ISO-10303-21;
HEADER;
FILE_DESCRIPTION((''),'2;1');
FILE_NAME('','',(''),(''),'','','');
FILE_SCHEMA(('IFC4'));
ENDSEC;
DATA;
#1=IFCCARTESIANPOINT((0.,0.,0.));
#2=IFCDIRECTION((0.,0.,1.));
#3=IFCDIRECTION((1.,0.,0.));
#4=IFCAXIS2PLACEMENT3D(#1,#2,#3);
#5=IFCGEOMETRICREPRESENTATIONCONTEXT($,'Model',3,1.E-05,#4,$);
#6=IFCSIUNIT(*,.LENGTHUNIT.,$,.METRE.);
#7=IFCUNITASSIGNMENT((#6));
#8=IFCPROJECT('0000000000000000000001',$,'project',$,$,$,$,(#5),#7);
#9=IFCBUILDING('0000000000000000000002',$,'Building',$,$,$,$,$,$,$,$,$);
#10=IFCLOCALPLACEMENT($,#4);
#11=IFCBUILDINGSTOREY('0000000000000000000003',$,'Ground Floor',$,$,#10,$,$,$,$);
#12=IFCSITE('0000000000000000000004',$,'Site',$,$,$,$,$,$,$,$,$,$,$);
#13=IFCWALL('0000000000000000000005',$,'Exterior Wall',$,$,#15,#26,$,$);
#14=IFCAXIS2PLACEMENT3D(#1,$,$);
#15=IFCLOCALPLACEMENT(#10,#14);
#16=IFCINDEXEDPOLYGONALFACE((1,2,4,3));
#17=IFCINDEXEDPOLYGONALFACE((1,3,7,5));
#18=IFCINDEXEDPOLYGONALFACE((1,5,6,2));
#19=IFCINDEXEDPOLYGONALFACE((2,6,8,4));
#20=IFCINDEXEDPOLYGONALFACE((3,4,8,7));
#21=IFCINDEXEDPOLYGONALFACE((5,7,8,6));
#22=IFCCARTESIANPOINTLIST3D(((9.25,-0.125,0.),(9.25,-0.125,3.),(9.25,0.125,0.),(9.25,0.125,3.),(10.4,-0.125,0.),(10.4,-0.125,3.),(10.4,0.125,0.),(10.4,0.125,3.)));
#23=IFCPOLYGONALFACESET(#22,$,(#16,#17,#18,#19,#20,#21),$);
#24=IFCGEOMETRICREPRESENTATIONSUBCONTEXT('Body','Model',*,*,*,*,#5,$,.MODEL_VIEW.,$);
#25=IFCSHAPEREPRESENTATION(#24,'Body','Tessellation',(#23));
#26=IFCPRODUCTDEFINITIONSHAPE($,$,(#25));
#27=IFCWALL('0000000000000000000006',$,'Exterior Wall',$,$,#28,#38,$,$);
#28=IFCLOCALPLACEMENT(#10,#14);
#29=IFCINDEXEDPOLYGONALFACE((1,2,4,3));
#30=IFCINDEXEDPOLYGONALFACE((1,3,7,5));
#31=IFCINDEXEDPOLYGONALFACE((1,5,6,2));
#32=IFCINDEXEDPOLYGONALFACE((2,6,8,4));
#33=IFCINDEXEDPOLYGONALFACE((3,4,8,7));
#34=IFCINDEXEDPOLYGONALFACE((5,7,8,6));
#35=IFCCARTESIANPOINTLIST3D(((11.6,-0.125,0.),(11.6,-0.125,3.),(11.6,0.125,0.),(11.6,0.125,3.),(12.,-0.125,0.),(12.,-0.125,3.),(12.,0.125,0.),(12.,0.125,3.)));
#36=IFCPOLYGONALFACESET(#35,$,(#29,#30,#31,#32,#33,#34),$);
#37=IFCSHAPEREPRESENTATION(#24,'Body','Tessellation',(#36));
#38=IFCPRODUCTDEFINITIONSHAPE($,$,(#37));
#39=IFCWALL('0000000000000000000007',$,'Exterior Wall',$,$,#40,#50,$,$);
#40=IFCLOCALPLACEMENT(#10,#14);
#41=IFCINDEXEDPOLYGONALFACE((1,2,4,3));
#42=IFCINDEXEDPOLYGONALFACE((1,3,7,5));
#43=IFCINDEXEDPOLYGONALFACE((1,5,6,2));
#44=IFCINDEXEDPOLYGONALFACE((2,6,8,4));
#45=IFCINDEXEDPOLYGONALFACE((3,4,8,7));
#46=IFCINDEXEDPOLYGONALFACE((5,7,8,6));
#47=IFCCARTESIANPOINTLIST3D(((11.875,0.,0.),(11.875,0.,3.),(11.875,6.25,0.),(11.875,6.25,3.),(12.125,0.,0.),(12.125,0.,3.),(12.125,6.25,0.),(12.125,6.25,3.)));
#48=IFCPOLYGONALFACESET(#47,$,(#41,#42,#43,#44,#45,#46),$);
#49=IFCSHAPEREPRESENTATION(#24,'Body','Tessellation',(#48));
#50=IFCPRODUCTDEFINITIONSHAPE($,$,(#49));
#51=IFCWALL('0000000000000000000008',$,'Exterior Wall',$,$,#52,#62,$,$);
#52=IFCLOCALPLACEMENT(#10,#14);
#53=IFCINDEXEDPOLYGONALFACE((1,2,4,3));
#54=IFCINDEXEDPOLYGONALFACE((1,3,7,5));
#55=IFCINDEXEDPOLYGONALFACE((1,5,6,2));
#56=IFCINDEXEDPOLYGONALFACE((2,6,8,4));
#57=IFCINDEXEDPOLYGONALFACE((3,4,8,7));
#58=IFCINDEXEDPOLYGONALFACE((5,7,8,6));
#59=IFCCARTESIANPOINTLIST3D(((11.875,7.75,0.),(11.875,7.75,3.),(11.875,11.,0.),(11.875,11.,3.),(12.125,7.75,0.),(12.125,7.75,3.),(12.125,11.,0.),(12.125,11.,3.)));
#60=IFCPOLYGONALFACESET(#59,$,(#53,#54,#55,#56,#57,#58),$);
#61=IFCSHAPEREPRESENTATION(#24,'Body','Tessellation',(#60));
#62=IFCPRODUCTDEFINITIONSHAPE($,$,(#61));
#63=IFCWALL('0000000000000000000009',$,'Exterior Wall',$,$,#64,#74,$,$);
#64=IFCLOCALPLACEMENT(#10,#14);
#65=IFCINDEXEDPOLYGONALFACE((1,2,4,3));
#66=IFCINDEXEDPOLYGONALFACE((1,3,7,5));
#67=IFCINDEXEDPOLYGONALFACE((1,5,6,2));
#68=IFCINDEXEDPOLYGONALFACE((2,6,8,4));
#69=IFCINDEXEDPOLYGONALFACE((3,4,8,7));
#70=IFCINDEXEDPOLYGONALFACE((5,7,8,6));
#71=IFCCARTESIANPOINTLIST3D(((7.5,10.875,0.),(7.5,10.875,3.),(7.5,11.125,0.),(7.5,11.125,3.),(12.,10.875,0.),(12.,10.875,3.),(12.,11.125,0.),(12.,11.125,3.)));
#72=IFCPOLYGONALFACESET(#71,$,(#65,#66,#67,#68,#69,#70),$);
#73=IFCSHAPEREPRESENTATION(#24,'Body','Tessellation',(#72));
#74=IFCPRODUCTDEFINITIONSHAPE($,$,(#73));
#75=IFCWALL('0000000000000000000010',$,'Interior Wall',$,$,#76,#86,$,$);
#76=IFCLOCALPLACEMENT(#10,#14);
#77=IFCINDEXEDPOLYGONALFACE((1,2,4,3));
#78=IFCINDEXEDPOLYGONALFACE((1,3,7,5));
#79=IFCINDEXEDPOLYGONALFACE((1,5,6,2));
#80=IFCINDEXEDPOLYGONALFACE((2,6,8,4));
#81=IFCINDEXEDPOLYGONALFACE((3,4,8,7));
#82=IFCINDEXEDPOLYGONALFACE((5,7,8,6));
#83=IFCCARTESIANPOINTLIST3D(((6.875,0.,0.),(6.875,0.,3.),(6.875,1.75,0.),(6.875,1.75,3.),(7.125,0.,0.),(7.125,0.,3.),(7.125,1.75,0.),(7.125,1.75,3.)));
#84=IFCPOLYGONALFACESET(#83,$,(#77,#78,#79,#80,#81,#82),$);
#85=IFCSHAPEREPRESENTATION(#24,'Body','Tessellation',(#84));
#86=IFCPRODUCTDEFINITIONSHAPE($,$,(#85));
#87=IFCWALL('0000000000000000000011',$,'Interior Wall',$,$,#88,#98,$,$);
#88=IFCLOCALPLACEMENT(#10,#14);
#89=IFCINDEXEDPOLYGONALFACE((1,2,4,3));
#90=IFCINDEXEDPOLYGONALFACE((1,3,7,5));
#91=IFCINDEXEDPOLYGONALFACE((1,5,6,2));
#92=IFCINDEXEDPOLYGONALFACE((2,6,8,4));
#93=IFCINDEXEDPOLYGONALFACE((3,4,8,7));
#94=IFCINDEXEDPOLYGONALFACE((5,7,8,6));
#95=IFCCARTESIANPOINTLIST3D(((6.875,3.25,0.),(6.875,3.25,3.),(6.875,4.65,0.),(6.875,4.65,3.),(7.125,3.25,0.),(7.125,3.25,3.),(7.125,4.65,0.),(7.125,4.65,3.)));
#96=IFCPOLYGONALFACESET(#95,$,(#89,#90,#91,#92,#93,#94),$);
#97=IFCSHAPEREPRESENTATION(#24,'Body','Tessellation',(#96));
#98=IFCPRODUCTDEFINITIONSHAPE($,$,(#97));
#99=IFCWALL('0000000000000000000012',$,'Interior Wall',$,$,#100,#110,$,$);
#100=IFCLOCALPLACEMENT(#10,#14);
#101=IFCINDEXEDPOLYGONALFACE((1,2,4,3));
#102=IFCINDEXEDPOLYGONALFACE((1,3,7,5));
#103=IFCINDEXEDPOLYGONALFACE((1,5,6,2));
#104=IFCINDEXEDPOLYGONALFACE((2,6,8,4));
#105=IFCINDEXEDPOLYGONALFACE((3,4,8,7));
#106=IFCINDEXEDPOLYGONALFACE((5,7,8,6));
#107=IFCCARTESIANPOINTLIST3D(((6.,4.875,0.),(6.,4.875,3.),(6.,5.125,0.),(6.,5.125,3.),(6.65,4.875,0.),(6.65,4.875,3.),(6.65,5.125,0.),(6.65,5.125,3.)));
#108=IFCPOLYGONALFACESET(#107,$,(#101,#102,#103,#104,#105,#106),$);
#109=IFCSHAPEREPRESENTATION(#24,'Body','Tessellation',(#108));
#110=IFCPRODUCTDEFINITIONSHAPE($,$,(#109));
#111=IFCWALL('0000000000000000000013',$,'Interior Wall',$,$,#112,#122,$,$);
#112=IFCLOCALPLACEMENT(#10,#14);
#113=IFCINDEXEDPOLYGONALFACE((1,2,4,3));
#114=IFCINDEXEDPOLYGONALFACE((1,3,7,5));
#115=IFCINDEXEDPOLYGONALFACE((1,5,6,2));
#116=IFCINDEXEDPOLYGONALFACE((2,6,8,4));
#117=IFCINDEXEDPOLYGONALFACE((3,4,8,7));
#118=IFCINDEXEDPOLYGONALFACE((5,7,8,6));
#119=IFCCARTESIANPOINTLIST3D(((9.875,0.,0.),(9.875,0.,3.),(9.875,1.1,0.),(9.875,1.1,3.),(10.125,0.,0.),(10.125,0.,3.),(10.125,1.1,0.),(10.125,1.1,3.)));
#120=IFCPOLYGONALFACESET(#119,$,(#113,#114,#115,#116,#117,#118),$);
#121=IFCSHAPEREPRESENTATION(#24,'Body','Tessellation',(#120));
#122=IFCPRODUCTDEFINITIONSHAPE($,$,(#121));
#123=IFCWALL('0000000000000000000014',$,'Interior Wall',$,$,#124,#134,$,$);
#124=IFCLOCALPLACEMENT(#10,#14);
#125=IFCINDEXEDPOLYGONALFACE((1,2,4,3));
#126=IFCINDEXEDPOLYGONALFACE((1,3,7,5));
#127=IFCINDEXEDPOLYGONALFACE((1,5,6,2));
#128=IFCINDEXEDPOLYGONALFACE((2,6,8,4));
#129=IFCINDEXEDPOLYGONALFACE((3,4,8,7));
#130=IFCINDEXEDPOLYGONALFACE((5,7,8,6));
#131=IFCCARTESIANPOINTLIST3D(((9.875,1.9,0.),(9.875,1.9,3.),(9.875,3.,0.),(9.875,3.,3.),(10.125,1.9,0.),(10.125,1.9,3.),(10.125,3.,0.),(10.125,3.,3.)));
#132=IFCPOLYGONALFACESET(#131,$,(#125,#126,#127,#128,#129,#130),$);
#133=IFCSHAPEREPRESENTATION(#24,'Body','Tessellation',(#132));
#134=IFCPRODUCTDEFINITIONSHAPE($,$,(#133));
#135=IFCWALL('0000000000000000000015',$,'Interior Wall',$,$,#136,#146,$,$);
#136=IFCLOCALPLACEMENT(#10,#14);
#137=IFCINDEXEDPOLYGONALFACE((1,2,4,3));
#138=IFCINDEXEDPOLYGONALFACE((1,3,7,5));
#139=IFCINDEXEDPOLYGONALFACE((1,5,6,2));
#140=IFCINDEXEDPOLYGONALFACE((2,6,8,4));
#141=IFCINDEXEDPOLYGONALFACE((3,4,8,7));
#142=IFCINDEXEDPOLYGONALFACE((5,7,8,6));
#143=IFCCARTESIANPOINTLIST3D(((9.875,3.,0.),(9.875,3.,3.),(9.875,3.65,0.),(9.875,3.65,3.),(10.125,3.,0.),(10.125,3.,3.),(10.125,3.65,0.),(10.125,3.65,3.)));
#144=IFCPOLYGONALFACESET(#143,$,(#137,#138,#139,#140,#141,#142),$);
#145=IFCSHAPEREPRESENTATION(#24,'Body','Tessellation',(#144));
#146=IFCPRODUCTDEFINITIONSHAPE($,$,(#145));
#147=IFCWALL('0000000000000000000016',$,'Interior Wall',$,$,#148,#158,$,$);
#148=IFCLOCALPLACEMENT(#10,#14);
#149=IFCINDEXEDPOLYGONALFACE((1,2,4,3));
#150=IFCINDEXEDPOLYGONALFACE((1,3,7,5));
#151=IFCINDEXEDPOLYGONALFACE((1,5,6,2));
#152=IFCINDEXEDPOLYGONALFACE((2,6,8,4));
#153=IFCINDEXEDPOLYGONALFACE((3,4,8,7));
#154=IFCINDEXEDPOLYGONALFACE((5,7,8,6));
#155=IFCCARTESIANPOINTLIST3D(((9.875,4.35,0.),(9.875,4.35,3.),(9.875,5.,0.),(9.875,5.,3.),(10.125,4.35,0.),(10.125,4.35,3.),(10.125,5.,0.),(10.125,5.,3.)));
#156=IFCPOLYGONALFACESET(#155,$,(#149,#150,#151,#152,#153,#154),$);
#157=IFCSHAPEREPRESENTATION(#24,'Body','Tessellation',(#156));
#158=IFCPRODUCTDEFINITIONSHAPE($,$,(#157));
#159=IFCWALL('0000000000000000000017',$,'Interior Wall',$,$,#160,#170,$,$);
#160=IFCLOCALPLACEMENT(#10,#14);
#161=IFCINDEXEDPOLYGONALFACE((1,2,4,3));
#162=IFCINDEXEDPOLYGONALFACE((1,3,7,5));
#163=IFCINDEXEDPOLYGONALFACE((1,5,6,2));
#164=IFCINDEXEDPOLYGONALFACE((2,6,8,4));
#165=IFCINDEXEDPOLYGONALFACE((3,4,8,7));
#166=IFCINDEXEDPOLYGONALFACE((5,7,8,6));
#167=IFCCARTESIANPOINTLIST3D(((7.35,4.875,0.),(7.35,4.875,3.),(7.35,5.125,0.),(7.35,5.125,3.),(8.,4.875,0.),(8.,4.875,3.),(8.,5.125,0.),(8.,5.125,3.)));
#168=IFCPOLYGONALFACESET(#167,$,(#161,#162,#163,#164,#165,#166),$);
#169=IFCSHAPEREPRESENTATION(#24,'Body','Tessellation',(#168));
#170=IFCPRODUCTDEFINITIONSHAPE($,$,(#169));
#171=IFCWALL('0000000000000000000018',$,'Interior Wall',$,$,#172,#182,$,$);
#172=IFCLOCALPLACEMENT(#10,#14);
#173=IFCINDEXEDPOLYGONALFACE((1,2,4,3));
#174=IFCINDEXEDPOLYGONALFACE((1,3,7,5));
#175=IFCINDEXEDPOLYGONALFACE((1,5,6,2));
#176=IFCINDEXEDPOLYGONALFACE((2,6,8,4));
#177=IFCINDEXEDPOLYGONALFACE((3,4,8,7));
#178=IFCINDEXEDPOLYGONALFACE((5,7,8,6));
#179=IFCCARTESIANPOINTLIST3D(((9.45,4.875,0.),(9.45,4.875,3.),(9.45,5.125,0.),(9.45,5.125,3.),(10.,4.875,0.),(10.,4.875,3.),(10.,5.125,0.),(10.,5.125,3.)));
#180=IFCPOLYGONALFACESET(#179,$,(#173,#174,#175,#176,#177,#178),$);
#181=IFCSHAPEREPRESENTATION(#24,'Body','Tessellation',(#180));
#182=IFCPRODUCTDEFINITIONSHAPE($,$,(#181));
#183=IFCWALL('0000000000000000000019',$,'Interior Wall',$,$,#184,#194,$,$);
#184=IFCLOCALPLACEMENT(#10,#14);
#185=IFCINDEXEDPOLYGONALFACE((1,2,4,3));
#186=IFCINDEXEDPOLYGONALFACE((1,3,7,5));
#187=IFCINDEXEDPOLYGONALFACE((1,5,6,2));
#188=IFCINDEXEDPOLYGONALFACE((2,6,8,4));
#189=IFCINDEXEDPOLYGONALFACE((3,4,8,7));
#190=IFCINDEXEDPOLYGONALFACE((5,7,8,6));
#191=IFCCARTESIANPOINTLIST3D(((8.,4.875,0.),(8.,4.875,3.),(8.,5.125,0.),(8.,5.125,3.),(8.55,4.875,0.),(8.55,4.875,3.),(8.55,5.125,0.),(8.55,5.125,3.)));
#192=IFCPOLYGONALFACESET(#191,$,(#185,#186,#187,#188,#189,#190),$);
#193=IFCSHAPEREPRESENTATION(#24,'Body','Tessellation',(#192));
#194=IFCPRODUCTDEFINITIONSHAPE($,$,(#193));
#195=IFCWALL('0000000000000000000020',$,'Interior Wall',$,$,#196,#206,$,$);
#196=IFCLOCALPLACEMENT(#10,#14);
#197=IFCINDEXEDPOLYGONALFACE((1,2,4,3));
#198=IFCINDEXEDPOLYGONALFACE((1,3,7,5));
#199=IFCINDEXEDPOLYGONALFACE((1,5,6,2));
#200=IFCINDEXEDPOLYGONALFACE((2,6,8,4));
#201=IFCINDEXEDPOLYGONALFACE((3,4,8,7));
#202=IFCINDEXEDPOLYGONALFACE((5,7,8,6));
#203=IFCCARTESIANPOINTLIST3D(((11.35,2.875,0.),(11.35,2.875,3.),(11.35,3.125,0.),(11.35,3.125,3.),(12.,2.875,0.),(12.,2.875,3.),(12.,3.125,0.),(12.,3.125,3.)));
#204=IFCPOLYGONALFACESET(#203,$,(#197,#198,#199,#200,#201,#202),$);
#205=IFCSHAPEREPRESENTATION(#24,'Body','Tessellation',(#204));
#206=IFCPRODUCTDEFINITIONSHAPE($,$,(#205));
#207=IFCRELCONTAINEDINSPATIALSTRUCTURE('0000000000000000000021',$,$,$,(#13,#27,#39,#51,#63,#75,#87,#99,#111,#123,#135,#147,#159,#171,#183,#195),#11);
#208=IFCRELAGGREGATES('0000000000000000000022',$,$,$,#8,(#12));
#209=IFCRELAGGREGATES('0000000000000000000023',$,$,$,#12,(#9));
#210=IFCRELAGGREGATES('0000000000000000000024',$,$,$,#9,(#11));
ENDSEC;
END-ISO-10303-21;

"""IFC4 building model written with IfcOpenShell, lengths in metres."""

from ifc_helpers import new_model, si_unit, frame, origin_with_axes, place, context, subcontext, project, spatial, indexed_curve, outline, extrude, element, save


model = new_model("IFC4")

# Units and contexts
model_context = context("Model", 3, precision=1e-05, world=origin_with_axes())
body_context = subcontext(model_context, "Body", "Model", "MODEL_VIEW")
ifc_project = project(units=[si_unit("LENGTHUNIT", "METRE")], contexts=[model_context])

# Site, building, storey
site = spatial("IfcSite", under=ifc_project, Name="Site")
building = spatial("IfcBuilding", under=site, Name="Building")
storey_placement = place(None, origin_with_axes())
storey = spatial("IfcBuildingStorey", under=building, at=storey_placement, Name="Ground Floor")

# Walls
wall_1_placement = place(storey_placement, frame((9.25, 0.0, 0.0), z_axis=(0.0, 0.0, 1.0), x_axis=(1.0, 0.0, 0.0)))
element("IfcWall", 1, at=wall_1_placement, inside=storey, Name="Exterior Wall", context=body_context, shape_type="SweptSolid", body=[
    extrude(outline(indexed_curve([(0.0, 0.0), (0.0, 0.25), (1.15, 0.25), (1.15, 0.0), (0.0, 0.0)], self_intersect=False)), frame((0.0, -0.125, 0.0), z_axis=(0.0, 0.0, 1.0), x_axis=(1.0, 0.0, 0.0)), (0.0, 0.0, 1.0), 3.0),
])
wall_2_placement = place(storey_placement, frame((11.6, 0.0, 0.0), z_axis=(0.0, 0.0, 1.0), x_axis=(1.0, 0.0, 0.0)))
element("IfcWall", 2, at=wall_2_placement, inside=storey, Name="Exterior Wall", context=body_context, shape_type="SweptSolid", body=[
    extrude(outline(indexed_curve([(0.0, 0.0), (0.0, 0.25), (0.4, 0.25), (0.4, 0.0), (0.0, 0.0)], self_intersect=False)), frame((0.0, -0.125, 0.0), z_axis=(0.0, 0.0, 1.0), x_axis=(1.0, 0.0, 0.0)), (0.0, 0.0, 1.0), 3.0),
])
wall_3_placement = place(storey_placement, frame((12.0, 0.0, 0.0), z_axis=(0.0, 0.0, 1.0), x_axis=(0.0, 1.0, 0.0)))
element("IfcWall", 3, at=wall_3_placement, inside=storey, Name="Exterior Wall", context=body_context, shape_type="SweptSolid", body=[
    extrude(outline(indexed_curve([(0.0, 0.0), (0.0, 0.25), (6.25, 0.25), (6.25, 0.0), (0.0, 0.0)], self_intersect=False)), frame((0.0, -0.125, 0.0), z_axis=(0.0, 0.0, 1.0), x_axis=(1.0, 0.0, 0.0)), (0.0, 0.0, 1.0), 3.0),
])
wall_4_placement = place(storey_placement, frame((12.0, 7.75, 0.0), z_axis=(0.0, 0.0, 1.0), x_axis=(0.0, 1.0, 0.0)))
element("IfcWall", 4, at=wall_4_placement, inside=storey, Name="Exterior Wall", context=body_context, shape_type="SweptSolid", body=[
    extrude(outline(indexed_curve([(0.0, 0.0), (0.0, 0.25), (3.25, 0.25), (3.25, 0.0), (0.0, 0.0)], self_intersect=False)), frame((0.0, -0.125, 0.0), z_axis=(0.0, 0.0, 1.0), x_axis=(1.0, 0.0, 0.0)), (0.0, 0.0, 1.0), 3.0),
])
wall_5_placement = place(storey_placement, frame((12.0, 11.0, 0.0), z_axis=(0.0, 0.0, 1.0), x_axis=(-1.0, 0.0, 0.0)))
element("IfcWall", 5, at=wall_5_placement, inside=storey, Name="Exterior Wall", context=body_context, shape_type="SweptSolid", body=[
    extrude(outline(indexed_curve([(0.0, 0.0), (0.0, 0.25), (4.5, 0.25), (4.5, 0.0), (0.0, 0.0)], self_intersect=False)), frame((0.0, -0.125, 0.0), z_axis=(0.0, 0.0, 1.0), x_axis=(1.0, 0.0, 0.0)), (0.0, 0.0, 1.0), 3.0),
])
wall_6_placement = place(storey_placement, frame((7.0, 0.0, 0.0), z_axis=(0.0, 0.0, 1.0), x_axis=(0.0, 1.0, 0.0)))
element("IfcWall", 6, at=wall_6_placement, inside=storey, Name="Interior Wall", context=body_context, shape_type="SweptSolid", body=[
    extrude(outline(indexed_curve([(0.0, 0.0), (0.0, 0.25), (1.75, 0.25), (1.75, 0.0), (0.0, 0.0)], self_intersect=False)), frame((0.0, -0.125, 0.0), z_axis=(0.0, 0.0, 1.0), x_axis=(1.0, 0.0, 0.0)), (0.0, 0.0, 1.0), 3.0),
])
wall_7_placement = place(storey_placement, frame((7.0, 3.25, 0.0), z_axis=(0.0, 0.0, 1.0), x_axis=(0.0, 1.0, 0.0)))
element("IfcWall", 7, at=wall_7_placement, inside=storey, Name="Interior Wall", context=body_context, shape_type="SweptSolid", body=[
    extrude(outline(indexed_curve([(0.0, 0.0), (0.0, 0.25), (1.4, 0.25), (1.4, 0.0), (0.0, 0.0)], self_intersect=False)), frame((0.0, -0.125, 0.0), z_axis=(0.0, 0.0, 1.0), x_axis=(1.0, 0.0, 0.0)), (0.0, 0.0, 1.0), 3.0),
])
wall_8_placement = place(storey_placement, frame((6.65, 5.0, 0.0), z_axis=(0.0, 0.0, 1.0), x_axis=(-1.0, 0.0, 0.0)))
element("IfcWall", 8, at=wall_8_placement, inside=storey, Name="Interior Wall", context=body_context, shape_type="SweptSolid", body=[
    extrude(outline(indexed_curve([(0.0, 0.0), (0.0, 0.25), (0.65, 0.25), (0.65, 0.0), (0.0, 0.0)], self_intersect=False)), frame((0.0, -0.125, 0.0), z_axis=(0.0, 0.0, 1.0), x_axis=(1.0, 0.0, 0.0)), (0.0, 0.0, 1.0), 3.0),
])
for number, where, z_axis, x_axis, name in (
    (9, (10.0, 0.0, 0.0), (0.0, 0.0, 1.0), (0.0, 1.0, 0.0), "Interior Wall"),
    (10, (10.0, 1.9, 0.0), (0.0, 0.0, 1.0), (0.0, 1.0, 0.0), "Interior Wall"),
):
    element("IfcWall", number, at=place(storey_placement, frame(where, z_axis=z_axis, x_axis=x_axis)), inside=storey, Name=name, context=body_context, shape_type="SweptSolid", body=[
        extrude(outline(indexed_curve([(0.0, 0.0), (0.0, 0.25), (1.1, 0.25), (1.1, 0.0), (0.0, 0.0)], self_intersect=False)), frame((0.0, -0.125, 0.0), z_axis=(0.0, 0.0, 1.0), x_axis=(1.0, 0.0, 0.0)), (0.0, 0.0, 1.0), 3.0),
    ])
wall_9_placement = place(storey_placement, frame((10.0, 3.0, 0.0), z_axis=(0.0, 0.0, 1.0), x_axis=(0.0, 1.0, 0.0)))
element("IfcWall", 11, at=wall_9_placement, inside=storey, Name="Interior Wall", context=body_context, shape_type="SweptSolid", body=[
    extrude(outline(indexed_curve([(0.0, 0.0), (0.0, 0.25), (0.65, 0.25), (0.65, 0.0), (0.0, 0.0)], self_intersect=False)), frame((0.0, -0.125, 0.0), z_axis=(0.0, 0.0, 1.0), x_axis=(1.0, 0.0, 0.0)), (0.0, 0.0, 1.0), 3.0),
])
for number, where, z_axis, x_axis, name in (
    (12, (10.0, 4.35, 0.0), (0.0, 0.0, 1.0), (0.0, 1.0, 0.0), "Interior Wall"),
    (13, (8.0, 5.0, 0.0), (0.0, 0.0, 1.0), (-1.0, 0.0, 0.0), "Interior Wall"),
):
    element("IfcWall", number, at=place(storey_placement, frame(where, z_axis=z_axis, x_axis=x_axis)), inside=storey, Name=name, context=body_context, shape_type="SweptSolid", body=[
        extrude(outline(indexed_curve([(0.0, 0.0), (0.0, 0.25), (0.65, 0.25), (0.65, 0.0), (0.0, 0.0)], self_intersect=False)), frame((0.0, -0.125, 0.0), z_axis=(0.0, 0.0, 1.0), x_axis=(1.0, 0.0, 0.0)), (0.0, 0.0, 1.0), 3.0),
    ])
for number, where, z_axis, x_axis, name in (
    (14, (10.0, 5.0, 0.0), (0.0, 0.0, 1.0), (-1.0, 0.0, 0.0), "Interior Wall"),
    (15, (8.55, 5.0, 0.0), (0.0, 0.0, 1.0), (-1.0, 0.0, 0.0), "Interior Wall"),
):
    element("IfcWall", number, at=place(storey_placement, frame(where, z_axis=z_axis, x_axis=x_axis)), inside=storey, Name=name, context=body_context, shape_type="SweptSolid", body=[
        extrude(outline(indexed_curve([(0.0, 0.0), (0.0, 0.25), (0.55, 0.25), (0.55, 0.0), (0.0, 0.0)], self_intersect=False)), frame((0.0, -0.125, 0.0), z_axis=(0.0, 0.0, 1.0), x_axis=(1.0, 0.0, 0.0)), (0.0, 0.0, 1.0), 3.0),
    ])
for number, where, z_axis, x_axis, name in (
    (16, (12.0, 3.0, 0.0), (0.0, 0.0, 1.0), (-1.0, 0.0, 0.0), "Interior Wall"),
):
    element("IfcWall", number, at=place(storey_placement, frame(where, z_axis=z_axis, x_axis=x_axis)), inside=storey, Name=name, context=body_context, shape_type="SweptSolid", body=[
        extrude(outline(indexed_curve([(0.0, 0.0), (0.0, 0.25), (0.65, 0.25), (0.65, 0.0), (0.0, 0.0)], self_intersect=False)), frame((0.0, -0.125, 0.0), z_axis=(0.0, 0.0, 1.0), x_axis=(1.0, 0.0, 0.0)), (0.0, 0.0, 1.0), 3.0),
    ])

save(model, "model.ifc")
